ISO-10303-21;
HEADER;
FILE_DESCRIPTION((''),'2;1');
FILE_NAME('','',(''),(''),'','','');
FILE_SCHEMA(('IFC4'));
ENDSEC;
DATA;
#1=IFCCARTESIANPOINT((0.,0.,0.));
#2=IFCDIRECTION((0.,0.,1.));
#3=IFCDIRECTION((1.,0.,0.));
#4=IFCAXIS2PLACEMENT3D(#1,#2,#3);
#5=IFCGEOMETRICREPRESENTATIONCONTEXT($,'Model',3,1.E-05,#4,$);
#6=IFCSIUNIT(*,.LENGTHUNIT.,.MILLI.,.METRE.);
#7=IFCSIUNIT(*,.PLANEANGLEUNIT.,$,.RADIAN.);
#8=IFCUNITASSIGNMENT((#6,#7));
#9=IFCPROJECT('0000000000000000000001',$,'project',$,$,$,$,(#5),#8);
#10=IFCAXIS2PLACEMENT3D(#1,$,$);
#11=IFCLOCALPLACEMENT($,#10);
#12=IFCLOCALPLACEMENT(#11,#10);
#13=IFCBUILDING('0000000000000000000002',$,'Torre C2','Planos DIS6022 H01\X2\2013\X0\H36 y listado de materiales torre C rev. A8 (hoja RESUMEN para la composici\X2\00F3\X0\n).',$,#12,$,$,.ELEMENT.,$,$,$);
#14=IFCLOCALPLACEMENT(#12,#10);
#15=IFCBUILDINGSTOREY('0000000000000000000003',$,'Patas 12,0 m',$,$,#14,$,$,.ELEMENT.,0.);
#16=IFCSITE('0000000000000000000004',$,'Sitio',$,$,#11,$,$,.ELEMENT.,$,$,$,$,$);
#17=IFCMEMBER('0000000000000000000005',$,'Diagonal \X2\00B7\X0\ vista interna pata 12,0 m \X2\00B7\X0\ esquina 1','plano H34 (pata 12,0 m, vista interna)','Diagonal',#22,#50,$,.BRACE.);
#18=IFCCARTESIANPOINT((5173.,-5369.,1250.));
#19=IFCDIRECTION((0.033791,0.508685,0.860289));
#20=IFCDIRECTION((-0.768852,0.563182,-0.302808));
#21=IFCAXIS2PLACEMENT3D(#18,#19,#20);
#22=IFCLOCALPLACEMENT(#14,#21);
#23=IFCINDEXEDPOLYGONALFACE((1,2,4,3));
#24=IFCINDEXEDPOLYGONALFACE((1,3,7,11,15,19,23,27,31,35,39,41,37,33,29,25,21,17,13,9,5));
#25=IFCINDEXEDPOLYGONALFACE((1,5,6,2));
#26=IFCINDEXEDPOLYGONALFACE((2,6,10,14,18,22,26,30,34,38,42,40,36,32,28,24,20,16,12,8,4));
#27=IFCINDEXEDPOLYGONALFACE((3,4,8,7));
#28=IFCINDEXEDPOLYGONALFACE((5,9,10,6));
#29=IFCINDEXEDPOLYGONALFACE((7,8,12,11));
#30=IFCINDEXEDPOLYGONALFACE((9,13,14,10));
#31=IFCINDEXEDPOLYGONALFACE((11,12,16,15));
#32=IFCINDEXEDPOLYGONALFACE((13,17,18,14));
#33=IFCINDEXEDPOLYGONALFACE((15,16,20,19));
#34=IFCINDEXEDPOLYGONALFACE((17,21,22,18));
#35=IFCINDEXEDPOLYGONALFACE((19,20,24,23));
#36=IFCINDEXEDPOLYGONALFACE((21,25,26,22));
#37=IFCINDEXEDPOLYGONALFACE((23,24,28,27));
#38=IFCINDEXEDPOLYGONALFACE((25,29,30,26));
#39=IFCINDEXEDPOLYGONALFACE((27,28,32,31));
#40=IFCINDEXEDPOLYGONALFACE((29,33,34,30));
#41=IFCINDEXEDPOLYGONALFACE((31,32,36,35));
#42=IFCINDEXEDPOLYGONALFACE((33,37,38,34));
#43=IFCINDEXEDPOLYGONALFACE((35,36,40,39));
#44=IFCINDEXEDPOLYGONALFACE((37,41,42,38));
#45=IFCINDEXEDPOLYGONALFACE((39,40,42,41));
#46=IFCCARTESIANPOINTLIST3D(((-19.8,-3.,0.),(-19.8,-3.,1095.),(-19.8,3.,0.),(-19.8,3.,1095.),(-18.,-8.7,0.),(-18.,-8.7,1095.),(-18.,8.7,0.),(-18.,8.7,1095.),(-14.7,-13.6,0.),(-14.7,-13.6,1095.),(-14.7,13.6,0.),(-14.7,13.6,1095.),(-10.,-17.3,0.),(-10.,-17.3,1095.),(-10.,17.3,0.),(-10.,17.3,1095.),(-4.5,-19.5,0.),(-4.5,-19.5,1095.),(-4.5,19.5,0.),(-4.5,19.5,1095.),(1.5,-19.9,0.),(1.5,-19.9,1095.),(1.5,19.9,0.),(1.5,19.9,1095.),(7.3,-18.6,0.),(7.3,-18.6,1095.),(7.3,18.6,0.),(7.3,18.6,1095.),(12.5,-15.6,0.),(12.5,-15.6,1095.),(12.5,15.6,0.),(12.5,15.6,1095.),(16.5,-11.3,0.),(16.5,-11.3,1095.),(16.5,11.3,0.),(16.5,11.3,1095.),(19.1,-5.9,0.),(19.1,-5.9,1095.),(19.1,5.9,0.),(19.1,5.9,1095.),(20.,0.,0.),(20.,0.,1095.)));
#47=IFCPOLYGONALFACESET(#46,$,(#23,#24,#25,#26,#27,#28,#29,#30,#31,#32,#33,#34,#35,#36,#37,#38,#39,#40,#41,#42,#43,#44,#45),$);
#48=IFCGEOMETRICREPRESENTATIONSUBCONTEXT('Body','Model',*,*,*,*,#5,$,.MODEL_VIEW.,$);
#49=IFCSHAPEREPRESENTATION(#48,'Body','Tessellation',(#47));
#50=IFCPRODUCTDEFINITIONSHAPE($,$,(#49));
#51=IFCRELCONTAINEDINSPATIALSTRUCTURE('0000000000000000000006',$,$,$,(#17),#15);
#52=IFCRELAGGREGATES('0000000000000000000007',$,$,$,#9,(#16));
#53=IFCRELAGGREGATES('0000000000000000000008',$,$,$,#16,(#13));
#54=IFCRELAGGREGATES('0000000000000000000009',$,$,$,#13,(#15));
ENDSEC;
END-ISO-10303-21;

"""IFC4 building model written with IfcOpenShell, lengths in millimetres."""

from ifc_helpers import new_model, si_unit, frame, origin, origin_with_axes, place, context, subcontext, project, spatial, circle, extrude, element, save


model = new_model("IFC4")

# Units and contexts
model_context = context("Model", 3, precision=1e-05, world=origin_with_axes())
body_context = subcontext(model_context, "Body", "Model", "MODEL_VIEW")
ifc_project = project(units=[si_unit("LENGTHUNIT", "METRE", prefix="MILLI"), si_unit("PLANEANGLEUNIT", "RADIAN")], contexts=[model_context])

# Site, building, storey
site_placement = place(None, origin())
site = spatial("IfcSite", under=ifc_project, at=site_placement, Name="Sitio", CompositionType="ELEMENT")
building_placement = place(site_placement, origin())
building = spatial("IfcBuilding", under=site, at=building_placement, Name="Torre C2", Description="Planos DIS6022 H01–H36 y listado de materiales torre C rev. A8 (hoja RESUMEN para la composición).", CompositionType="ELEMENT")
storey_placement = place(building_placement, origin())
storey = spatial("IfcBuildingStorey", under=building, at=storey_placement, Name="Patas 12,0 m", CompositionType="ELEMENT", Elevation=0.0)

# Member
member_1_placement = place(storey_placement, frame((5173.0, -5369.0, 1250.0), z_axis=(0.033791, 0.508685, 0.860289), x_axis=(-0.768852, 0.563182, -0.302808)))
element("IfcMember", 1, at=member_1_placement, inside=storey, Name="Diagonal · vista interna pata 12,0 m · esquina 1", Description="plano H34 (pata 12,0 m, vista interna)", ObjectType="Diagonal", PredefinedType="BRACE", context=body_context, shape_type="SweptSolid", body=[
    extrude(circle(Radius=20.0), None, (0.0, 0.0, 1.0), 1095.0),
])

save(model, "model.ifc")
